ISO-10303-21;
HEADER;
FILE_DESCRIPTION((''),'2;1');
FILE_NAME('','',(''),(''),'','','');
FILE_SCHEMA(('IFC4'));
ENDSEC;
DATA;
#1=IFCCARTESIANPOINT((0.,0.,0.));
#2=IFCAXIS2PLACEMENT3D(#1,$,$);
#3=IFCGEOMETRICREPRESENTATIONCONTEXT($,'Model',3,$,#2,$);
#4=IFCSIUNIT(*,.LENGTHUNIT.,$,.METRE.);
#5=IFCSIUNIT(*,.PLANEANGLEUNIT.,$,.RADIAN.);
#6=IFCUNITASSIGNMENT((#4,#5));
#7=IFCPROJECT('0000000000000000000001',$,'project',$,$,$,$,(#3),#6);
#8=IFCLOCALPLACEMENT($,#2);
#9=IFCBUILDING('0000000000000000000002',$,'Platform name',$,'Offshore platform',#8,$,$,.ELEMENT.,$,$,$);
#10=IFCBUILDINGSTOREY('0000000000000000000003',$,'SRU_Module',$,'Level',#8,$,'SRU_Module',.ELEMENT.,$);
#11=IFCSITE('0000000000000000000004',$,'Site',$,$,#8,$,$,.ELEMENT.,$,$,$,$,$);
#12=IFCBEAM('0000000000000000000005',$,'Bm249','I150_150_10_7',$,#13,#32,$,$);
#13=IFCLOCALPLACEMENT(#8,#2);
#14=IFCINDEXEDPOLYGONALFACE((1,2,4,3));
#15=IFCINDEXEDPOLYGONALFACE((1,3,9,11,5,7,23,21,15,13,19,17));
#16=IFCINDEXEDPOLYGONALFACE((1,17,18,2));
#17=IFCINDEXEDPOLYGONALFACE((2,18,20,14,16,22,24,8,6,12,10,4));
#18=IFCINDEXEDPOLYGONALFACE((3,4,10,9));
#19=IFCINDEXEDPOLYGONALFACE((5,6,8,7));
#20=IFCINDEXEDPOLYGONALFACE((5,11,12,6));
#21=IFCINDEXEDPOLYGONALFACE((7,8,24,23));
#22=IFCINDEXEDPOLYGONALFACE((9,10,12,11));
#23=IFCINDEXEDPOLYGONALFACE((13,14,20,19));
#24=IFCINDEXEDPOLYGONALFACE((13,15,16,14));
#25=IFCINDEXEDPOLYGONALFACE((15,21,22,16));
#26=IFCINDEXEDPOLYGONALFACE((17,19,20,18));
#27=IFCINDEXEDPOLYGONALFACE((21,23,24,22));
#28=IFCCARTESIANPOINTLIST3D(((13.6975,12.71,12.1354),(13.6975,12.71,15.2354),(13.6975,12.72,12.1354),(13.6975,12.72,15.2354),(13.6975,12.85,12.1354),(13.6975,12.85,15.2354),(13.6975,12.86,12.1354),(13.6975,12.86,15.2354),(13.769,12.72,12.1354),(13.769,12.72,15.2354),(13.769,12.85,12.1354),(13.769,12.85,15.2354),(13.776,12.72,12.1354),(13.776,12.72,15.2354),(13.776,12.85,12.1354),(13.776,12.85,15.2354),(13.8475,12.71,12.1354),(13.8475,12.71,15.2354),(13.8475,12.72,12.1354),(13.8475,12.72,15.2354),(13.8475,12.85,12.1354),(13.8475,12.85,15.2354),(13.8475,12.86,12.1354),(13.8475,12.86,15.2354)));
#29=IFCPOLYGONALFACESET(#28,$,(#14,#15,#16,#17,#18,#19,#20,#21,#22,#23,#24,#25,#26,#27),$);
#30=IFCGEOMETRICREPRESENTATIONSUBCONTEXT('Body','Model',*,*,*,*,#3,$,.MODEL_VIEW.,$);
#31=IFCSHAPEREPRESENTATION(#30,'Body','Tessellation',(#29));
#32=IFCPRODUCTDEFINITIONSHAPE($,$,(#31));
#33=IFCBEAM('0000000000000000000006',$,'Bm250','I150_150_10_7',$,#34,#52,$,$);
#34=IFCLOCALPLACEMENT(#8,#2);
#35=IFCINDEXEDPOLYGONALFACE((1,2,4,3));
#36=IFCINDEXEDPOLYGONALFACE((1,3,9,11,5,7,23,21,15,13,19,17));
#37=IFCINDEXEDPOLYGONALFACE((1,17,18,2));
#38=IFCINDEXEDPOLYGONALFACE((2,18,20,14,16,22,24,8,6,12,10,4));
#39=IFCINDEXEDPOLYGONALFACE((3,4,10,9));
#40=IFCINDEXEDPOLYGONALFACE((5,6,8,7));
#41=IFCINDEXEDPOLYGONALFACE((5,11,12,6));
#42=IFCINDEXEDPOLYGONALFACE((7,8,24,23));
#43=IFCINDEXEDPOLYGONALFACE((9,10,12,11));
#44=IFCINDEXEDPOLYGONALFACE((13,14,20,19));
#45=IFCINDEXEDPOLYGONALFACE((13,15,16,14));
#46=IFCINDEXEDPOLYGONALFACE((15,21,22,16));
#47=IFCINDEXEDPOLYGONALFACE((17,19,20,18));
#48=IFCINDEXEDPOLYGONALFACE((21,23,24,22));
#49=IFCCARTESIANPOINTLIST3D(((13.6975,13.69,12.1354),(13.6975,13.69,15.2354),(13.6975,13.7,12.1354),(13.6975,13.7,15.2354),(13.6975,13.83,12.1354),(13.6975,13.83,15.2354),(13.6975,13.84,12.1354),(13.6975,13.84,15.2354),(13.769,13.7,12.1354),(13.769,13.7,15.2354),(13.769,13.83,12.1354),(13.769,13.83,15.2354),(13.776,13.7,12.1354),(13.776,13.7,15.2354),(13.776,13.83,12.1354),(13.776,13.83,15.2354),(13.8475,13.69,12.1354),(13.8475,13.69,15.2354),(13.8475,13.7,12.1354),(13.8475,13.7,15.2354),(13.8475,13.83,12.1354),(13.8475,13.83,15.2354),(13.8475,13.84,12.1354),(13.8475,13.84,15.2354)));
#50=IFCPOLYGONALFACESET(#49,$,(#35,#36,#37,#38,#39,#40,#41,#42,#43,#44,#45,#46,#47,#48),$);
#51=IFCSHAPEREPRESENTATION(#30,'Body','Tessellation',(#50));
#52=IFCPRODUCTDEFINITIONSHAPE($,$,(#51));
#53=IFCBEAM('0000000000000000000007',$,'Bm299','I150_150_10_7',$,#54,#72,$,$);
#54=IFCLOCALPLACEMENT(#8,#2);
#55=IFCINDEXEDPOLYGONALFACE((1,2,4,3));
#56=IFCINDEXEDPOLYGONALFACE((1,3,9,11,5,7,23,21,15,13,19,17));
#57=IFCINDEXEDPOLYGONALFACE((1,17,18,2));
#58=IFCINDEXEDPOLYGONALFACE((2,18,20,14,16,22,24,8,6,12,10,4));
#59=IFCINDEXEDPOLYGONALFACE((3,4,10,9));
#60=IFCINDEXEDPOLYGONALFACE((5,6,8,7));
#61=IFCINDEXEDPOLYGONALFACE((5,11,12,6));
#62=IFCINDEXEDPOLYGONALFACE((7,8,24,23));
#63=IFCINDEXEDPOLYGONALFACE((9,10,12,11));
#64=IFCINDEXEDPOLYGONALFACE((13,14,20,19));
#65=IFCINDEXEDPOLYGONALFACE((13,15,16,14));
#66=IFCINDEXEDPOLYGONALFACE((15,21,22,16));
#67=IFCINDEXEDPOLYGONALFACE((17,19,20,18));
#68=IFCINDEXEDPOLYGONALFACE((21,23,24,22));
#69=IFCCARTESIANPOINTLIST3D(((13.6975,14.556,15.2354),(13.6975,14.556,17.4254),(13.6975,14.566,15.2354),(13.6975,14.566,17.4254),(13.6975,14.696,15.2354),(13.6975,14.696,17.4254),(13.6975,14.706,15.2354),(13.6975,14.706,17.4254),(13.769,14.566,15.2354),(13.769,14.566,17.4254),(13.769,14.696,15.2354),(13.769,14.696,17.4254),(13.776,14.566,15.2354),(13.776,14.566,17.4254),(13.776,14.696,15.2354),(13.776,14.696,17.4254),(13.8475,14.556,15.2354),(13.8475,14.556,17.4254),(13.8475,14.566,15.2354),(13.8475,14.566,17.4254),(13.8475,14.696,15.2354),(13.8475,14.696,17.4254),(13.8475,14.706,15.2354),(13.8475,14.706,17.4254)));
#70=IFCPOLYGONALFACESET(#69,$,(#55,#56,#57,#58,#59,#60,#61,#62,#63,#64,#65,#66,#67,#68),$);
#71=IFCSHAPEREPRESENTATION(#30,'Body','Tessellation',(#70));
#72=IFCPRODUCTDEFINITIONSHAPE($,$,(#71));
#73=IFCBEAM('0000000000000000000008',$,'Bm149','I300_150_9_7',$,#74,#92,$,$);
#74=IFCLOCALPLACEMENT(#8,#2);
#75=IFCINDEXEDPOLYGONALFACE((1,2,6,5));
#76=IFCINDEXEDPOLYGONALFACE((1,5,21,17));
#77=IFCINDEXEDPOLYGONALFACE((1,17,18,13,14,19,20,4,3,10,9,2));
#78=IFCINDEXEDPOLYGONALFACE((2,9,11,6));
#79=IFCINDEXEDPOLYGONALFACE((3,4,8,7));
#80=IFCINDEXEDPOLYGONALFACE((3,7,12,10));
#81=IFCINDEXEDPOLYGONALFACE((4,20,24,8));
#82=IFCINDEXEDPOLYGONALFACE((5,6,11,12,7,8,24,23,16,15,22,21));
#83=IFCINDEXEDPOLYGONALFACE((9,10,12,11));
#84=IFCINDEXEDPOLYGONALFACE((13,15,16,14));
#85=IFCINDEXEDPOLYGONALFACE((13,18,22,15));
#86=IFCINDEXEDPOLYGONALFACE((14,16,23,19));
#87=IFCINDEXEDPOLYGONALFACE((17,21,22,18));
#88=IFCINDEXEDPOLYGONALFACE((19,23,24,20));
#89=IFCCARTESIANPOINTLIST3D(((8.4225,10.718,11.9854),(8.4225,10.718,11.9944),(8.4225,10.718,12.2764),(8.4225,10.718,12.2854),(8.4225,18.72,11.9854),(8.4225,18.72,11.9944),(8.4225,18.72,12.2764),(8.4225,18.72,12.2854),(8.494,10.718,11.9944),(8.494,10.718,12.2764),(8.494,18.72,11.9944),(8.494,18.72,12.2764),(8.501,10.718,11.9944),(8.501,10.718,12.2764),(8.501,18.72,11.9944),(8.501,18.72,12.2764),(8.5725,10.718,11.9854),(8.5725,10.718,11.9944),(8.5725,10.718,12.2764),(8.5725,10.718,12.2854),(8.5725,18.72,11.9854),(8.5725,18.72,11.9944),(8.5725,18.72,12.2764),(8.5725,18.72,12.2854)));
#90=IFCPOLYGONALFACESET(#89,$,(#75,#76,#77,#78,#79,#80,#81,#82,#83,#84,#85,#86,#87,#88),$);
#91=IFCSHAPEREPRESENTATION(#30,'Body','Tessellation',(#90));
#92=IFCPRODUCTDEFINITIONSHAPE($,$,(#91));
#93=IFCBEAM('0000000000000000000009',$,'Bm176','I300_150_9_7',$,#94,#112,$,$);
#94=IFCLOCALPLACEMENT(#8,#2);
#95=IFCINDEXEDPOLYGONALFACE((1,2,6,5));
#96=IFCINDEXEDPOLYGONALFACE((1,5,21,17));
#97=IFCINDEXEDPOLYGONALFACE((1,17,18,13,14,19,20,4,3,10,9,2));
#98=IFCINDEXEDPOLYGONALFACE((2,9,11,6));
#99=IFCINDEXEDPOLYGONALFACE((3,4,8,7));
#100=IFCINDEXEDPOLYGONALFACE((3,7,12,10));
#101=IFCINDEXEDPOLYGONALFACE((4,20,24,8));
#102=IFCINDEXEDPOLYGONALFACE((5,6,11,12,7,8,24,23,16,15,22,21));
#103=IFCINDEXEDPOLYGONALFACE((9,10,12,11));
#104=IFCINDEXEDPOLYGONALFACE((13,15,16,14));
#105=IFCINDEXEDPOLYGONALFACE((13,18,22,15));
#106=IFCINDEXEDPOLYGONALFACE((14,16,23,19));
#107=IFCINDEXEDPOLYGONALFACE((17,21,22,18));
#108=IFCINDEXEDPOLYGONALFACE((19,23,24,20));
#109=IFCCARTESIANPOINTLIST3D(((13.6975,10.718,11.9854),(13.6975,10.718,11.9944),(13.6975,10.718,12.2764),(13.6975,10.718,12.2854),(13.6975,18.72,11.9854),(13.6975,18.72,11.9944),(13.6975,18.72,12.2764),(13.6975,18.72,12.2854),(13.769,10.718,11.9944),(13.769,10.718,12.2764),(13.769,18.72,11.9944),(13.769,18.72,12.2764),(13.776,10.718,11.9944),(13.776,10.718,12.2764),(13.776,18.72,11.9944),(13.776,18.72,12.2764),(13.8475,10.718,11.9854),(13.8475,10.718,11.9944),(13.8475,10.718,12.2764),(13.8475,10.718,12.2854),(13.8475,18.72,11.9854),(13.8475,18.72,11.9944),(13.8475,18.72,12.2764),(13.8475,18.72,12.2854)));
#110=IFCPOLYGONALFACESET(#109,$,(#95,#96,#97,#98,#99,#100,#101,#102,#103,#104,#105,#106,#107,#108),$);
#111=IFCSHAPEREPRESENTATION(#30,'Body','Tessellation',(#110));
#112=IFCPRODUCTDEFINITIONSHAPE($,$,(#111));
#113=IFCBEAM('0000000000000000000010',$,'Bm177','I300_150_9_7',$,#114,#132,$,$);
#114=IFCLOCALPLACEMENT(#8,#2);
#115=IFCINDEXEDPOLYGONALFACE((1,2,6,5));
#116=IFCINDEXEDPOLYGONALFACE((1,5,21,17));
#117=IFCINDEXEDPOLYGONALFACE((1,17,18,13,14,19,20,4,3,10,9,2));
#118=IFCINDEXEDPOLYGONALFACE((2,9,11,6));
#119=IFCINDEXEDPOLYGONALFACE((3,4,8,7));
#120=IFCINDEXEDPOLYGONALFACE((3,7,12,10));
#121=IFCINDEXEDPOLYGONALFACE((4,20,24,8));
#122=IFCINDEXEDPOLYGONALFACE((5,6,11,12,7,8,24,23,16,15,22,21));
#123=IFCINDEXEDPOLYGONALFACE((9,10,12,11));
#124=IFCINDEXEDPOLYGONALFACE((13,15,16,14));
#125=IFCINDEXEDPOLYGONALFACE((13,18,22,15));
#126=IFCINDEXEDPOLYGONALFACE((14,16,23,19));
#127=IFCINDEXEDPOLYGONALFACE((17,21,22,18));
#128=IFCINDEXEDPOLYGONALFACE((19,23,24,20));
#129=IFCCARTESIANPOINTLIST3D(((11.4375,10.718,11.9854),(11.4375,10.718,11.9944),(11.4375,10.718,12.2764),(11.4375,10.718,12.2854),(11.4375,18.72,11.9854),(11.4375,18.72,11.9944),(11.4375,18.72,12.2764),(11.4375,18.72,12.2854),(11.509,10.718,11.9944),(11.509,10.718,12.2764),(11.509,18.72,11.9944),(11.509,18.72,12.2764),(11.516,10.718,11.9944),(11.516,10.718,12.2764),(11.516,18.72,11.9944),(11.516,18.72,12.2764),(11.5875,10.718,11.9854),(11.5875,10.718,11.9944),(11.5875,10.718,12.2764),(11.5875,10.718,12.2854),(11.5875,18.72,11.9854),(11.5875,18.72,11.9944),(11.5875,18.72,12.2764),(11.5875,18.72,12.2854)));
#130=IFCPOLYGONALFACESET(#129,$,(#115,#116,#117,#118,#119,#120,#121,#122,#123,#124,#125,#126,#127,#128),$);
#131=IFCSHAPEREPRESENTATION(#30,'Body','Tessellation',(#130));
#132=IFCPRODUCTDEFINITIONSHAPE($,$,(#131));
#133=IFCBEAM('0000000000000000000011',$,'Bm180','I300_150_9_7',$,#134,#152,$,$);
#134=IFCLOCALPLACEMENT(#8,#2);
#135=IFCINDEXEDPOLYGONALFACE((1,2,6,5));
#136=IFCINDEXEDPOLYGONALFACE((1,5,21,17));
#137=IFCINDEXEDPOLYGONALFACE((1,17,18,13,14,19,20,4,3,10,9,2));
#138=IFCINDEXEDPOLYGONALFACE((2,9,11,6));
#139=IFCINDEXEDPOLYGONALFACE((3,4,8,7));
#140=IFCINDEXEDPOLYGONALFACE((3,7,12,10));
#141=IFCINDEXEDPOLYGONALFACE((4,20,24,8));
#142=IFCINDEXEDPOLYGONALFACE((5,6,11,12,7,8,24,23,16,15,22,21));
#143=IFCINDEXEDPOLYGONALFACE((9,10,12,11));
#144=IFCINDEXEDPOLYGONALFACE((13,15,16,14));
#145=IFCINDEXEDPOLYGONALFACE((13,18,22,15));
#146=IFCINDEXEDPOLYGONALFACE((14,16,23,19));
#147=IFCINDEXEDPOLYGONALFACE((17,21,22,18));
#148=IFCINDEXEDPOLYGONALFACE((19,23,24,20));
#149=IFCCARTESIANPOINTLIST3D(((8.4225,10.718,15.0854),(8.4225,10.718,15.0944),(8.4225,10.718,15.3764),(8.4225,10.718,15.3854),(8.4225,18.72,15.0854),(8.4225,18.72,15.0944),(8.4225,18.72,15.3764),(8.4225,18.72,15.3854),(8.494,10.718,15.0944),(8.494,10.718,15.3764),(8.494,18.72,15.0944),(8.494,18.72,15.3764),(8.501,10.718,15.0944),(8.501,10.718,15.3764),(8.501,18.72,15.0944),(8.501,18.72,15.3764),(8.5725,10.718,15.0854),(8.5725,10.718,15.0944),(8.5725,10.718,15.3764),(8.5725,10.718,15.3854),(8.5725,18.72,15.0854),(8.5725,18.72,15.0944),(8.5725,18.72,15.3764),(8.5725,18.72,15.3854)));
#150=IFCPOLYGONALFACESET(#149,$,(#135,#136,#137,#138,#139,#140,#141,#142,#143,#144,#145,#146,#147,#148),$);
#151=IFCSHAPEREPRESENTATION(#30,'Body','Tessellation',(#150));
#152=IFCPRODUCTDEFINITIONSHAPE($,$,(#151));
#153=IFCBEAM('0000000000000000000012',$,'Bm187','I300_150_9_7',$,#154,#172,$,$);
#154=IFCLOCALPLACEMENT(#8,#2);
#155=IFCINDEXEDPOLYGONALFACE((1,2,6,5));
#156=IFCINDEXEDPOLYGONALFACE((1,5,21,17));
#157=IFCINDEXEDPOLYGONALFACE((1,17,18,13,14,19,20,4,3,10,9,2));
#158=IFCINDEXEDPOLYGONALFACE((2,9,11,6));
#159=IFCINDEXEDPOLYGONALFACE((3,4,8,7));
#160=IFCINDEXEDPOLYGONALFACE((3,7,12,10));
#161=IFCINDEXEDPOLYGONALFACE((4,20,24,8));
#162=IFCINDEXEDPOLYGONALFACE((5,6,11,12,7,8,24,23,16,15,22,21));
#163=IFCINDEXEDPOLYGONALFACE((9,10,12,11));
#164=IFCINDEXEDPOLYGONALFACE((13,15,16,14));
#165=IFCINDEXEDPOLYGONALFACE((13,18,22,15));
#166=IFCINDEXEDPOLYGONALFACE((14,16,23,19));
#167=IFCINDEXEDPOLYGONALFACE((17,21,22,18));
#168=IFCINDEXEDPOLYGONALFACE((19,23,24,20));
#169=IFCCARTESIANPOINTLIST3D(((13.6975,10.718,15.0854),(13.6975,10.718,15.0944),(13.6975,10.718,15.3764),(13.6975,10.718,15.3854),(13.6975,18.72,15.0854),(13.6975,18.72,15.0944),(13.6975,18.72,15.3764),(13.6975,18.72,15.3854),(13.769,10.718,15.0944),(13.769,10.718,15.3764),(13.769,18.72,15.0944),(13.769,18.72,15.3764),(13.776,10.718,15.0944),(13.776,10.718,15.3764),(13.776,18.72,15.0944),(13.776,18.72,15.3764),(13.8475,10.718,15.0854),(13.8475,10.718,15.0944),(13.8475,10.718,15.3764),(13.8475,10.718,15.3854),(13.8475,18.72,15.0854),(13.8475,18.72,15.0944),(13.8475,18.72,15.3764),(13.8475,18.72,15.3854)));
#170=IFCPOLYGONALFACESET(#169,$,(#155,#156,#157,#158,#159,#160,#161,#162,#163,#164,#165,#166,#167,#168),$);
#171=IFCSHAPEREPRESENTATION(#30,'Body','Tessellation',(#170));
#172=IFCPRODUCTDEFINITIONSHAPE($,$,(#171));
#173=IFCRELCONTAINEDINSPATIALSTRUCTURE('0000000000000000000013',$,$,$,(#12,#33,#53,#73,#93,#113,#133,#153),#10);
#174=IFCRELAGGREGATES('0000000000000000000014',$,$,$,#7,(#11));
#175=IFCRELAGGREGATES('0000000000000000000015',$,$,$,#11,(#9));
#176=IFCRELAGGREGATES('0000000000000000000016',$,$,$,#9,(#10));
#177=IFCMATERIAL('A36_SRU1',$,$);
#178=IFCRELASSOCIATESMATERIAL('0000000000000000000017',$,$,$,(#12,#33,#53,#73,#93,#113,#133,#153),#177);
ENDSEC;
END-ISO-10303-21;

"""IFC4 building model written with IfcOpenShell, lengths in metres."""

from ifc_helpers import new_model, si_unit, frame, origin, origin_with_axes, origin_2d, place, context, subcontext, project, spatial, i_section, extrude, source, transform, mapped, material, element, save


model = new_model("IFC4")

# Units and contexts
model_context = context("Model", 3, world=origin())
body_context = subcontext(model_context, "Body", "Model", "MODEL_VIEW")
ifc_project = project(units=[si_unit("LENGTHUNIT", "METRE"), si_unit("PLANEANGLEUNIT", "RADIAN")], contexts=[model_context])

# Site, building, storey
placement_1 = place(None, origin())
site = spatial("IfcSite", under=ifc_project, at=placement_1, Name="Site", CompositionType="ELEMENT")
building = spatial("IfcBuilding", under=site, at=placement_1, Name="Platform name", ObjectType="Offshore platform", CompositionType="ELEMENT")
storey = spatial("IfcBuildingStorey", under=building, at=placement_1, Name="SRU_Module", ObjectType="Level", LongName="SRU_Module", CompositionType="ELEMENT")

# Beams
ifc_material = material(Name="A36_SRU1")
shared_shape_1 = source(origin(), body_context, "Body", "SweptSolid", [
    extrude(i_section(OverallWidth=0.15, OverallDepth=0.15, WebThickness=0.007, FlangeThickness=0.01, FilletRadius=0.0, at=origin_2d()), origin_with_axes(), (0.0, 0.0, 1.0), 3.1),
])
placement_2 = place(None, origin())
placement_3 = place(placement_2, origin())
placement_4 = place(placement_3, origin())
beam_1_placement = place(placement_4, frame((13.7725, 12.785, 12.1354)))
element("IfcBeam", 1, at=beam_1_placement, inside=storey, material=ifc_material, Name="Bm249", Description="I150_150_10_7", context=body_context, shape_type="MappedRepresentation", body=[
    mapped(shared_shape_1, transform((0.0, 0.0, 0.0), scale=1.0)),
])
shared_shape_2 = source(origin(), body_context, "Body", "SweptSolid", [
    extrude(i_section(OverallWidth=0.15, OverallDepth=0.15, WebThickness=0.007, FlangeThickness=0.01, FilletRadius=0.0, at=origin_2d()), origin_with_axes(), (0.0, 0.0, 1.0), 3.1),
])
placement_5 = place(None, origin())
placement_6 = place(placement_5, origin())
placement_7 = place(placement_6, origin())
beam_2_placement = place(placement_7, frame((13.7725, 13.765, 12.1354)))
element("IfcBeam", 2, at=beam_2_placement, inside=storey, material=ifc_material, Name="Bm250", Description="I150_150_10_7", context=body_context, shape_type="MappedRepresentation", body=[
    mapped(shared_shape_2, transform((0.0, 0.0, 0.0), scale=1.0)),
])
shared_shape_3 = source(origin(), body_context, "Body", "SweptSolid", [
    extrude(i_section(OverallWidth=0.15, OverallDepth=0.15, WebThickness=0.007, FlangeThickness=0.01, FilletRadius=0.0, at=origin_2d()), origin_with_axes(), (0.0, 0.0, 1.0), 2.19),
])
placement_8 = place(None, origin())
placement_9 = place(placement_8, origin())
placement_10 = place(placement_9, origin())
beam_3_placement = place(placement_10, frame((13.7725, 14.631, 15.2354)))
element("IfcBeam", 3, at=beam_3_placement, inside=storey, material=ifc_material, Name="Bm299", Description="I150_150_10_7", context=body_context, shape_type="MappedRepresentation", body=[
    mapped(shared_shape_3, transform((0.0, 0.0, 0.0), scale=1.0)),
])
shared_shape_4 = source(origin(), body_context, "Body", "SweptSolid", [
    extrude(i_section(OverallWidth=0.15, OverallDepth=0.3, WebThickness=0.007, FlangeThickness=0.009, FilletRadius=0.0, at=origin_2d()), frame((0.0, 0.0, 0.0), z_axis=(0.0, 1.0, 0.0), x_axis=(-1.0, 0.0, 0.0)), (0.0, 0.0, 1.0), 8.002),
])
placement_11 = place(None, origin())
placement_12 = place(placement_11, origin())
placement_13 = place(placement_12, origin())
beam_4_placement = place(placement_13, frame((8.4975, 10.718, 12.1354)))
element("IfcBeam", 4, at=beam_4_placement, inside=storey, material=ifc_material, Name="Bm149", Description="I300_150_9_7", context=body_context, shape_type="MappedRepresentation", body=[
    mapped(shared_shape_4, transform((0.0, 0.0, 0.0), scale=1.0)),
])
shared_shape_5 = source(origin(), body_context, "Body", "SweptSolid", [
    extrude(i_section(OverallWidth=0.15, OverallDepth=0.3, WebThickness=0.007, FlangeThickness=0.009, FilletRadius=0.0, at=origin_2d()), frame((0.0, 0.0, 0.0), z_axis=(0.0, 1.0, 0.0), x_axis=(-1.0, 0.0, 0.0)), (0.0, 0.0, 1.0), 8.002),
])
placement_14 = place(None, origin())
placement_15 = place(placement_14, origin())
placement_16 = place(placement_15, origin())
beam_5_placement = place(placement_16, frame((13.7725, 10.718, 12.1354)))
element("IfcBeam", 5, at=beam_5_placement, inside=storey, material=ifc_material, Name="Bm176", Description="I300_150_9_7", context=body_context, shape_type="MappedRepresentation", body=[
    mapped(shared_shape_5, transform((0.0, 0.0, 0.0), scale=1.0)),
])
shared_shape_6 = source(origin(), body_context, "Body", "SweptSolid", [
    extrude(i_section(OverallWidth=0.15, OverallDepth=0.3, WebThickness=0.007, FlangeThickness=0.009, FilletRadius=0.0, at=origin_2d()), frame((0.0, 0.0, 0.0), z_axis=(0.0, 1.0, 0.0), x_axis=(-1.0, 0.0, 0.0)), (0.0, 0.0, 1.0), 8.002),
])
placement_17 = place(None, origin())
placement_18 = place(placement_17, origin())
placement_19 = place(placement_18, origin())
beam_6_placement = place(placement_19, frame((11.5125, 10.718, 12.1354)))
element("IfcBeam", 6, at=beam_6_placement, inside=storey, material=ifc_material, Name="Bm177", Description="I300_150_9_7", context=body_context, shape_type="MappedRepresentation", body=[
    mapped(shared_shape_6, transform((0.0, 0.0, 0.0), scale=1.0)),
])
shared_shape_7 = source(origin(), body_context, "Body", "SweptSolid", [
    extrude(i_section(OverallWidth=0.15, OverallDepth=0.3, WebThickness=0.007, FlangeThickness=0.009, FilletRadius=0.0, at=origin_2d()), frame((0.0, 0.0, 0.0), z_axis=(0.0, 1.0, 0.0), x_axis=(-1.0, 0.0, 0.0)), (0.0, 0.0, 1.0), 8.002),
])
placement_20 = place(None, origin())
placement_21 = place(placement_20, origin())
placement_22 = place(placement_21, origin())
beam_7_placement = place(placement_22, frame((8.4975, 10.718, 15.2354)))
element("IfcBeam", 7, at=beam_7_placement, inside=storey, material=ifc_material, Name="Bm180", Description="I300_150_9_7", context=body_context, shape_type="MappedRepresentation", body=[
    mapped(shared_shape_7, transform((0.0, 0.0, 0.0), scale=1.0)),
])
shared_shape_8 = source(origin(), body_context, "Body", "SweptSolid", [
    extrude(i_section(OverallWidth=0.15, OverallDepth=0.3, WebThickness=0.007, FlangeThickness=0.009, FilletRadius=0.0, at=origin_2d()), frame((0.0, 0.0, 0.0), z_axis=(0.0, 1.0, 0.0), x_axis=(-1.0, 0.0, 0.0)), (0.0, 0.0, 1.0), 8.002),
])
placement_23 = place(None, origin())
placement_24 = place(placement_23, origin())
placement_25 = place(placement_24, origin())
beam_8_placement = place(placement_25, frame((13.7725, 10.718, 15.2354)))
element("IfcBeam", 8, at=beam_8_placement, inside=storey, material=ifc_material, Name="Bm187", Description="I300_150_9_7", context=body_context, shape_type="MappedRepresentation", body=[
    mapped(shared_shape_8, transform((0.0, 0.0, 0.0), scale=1.0)),
])

save(model, "model.ifc")
